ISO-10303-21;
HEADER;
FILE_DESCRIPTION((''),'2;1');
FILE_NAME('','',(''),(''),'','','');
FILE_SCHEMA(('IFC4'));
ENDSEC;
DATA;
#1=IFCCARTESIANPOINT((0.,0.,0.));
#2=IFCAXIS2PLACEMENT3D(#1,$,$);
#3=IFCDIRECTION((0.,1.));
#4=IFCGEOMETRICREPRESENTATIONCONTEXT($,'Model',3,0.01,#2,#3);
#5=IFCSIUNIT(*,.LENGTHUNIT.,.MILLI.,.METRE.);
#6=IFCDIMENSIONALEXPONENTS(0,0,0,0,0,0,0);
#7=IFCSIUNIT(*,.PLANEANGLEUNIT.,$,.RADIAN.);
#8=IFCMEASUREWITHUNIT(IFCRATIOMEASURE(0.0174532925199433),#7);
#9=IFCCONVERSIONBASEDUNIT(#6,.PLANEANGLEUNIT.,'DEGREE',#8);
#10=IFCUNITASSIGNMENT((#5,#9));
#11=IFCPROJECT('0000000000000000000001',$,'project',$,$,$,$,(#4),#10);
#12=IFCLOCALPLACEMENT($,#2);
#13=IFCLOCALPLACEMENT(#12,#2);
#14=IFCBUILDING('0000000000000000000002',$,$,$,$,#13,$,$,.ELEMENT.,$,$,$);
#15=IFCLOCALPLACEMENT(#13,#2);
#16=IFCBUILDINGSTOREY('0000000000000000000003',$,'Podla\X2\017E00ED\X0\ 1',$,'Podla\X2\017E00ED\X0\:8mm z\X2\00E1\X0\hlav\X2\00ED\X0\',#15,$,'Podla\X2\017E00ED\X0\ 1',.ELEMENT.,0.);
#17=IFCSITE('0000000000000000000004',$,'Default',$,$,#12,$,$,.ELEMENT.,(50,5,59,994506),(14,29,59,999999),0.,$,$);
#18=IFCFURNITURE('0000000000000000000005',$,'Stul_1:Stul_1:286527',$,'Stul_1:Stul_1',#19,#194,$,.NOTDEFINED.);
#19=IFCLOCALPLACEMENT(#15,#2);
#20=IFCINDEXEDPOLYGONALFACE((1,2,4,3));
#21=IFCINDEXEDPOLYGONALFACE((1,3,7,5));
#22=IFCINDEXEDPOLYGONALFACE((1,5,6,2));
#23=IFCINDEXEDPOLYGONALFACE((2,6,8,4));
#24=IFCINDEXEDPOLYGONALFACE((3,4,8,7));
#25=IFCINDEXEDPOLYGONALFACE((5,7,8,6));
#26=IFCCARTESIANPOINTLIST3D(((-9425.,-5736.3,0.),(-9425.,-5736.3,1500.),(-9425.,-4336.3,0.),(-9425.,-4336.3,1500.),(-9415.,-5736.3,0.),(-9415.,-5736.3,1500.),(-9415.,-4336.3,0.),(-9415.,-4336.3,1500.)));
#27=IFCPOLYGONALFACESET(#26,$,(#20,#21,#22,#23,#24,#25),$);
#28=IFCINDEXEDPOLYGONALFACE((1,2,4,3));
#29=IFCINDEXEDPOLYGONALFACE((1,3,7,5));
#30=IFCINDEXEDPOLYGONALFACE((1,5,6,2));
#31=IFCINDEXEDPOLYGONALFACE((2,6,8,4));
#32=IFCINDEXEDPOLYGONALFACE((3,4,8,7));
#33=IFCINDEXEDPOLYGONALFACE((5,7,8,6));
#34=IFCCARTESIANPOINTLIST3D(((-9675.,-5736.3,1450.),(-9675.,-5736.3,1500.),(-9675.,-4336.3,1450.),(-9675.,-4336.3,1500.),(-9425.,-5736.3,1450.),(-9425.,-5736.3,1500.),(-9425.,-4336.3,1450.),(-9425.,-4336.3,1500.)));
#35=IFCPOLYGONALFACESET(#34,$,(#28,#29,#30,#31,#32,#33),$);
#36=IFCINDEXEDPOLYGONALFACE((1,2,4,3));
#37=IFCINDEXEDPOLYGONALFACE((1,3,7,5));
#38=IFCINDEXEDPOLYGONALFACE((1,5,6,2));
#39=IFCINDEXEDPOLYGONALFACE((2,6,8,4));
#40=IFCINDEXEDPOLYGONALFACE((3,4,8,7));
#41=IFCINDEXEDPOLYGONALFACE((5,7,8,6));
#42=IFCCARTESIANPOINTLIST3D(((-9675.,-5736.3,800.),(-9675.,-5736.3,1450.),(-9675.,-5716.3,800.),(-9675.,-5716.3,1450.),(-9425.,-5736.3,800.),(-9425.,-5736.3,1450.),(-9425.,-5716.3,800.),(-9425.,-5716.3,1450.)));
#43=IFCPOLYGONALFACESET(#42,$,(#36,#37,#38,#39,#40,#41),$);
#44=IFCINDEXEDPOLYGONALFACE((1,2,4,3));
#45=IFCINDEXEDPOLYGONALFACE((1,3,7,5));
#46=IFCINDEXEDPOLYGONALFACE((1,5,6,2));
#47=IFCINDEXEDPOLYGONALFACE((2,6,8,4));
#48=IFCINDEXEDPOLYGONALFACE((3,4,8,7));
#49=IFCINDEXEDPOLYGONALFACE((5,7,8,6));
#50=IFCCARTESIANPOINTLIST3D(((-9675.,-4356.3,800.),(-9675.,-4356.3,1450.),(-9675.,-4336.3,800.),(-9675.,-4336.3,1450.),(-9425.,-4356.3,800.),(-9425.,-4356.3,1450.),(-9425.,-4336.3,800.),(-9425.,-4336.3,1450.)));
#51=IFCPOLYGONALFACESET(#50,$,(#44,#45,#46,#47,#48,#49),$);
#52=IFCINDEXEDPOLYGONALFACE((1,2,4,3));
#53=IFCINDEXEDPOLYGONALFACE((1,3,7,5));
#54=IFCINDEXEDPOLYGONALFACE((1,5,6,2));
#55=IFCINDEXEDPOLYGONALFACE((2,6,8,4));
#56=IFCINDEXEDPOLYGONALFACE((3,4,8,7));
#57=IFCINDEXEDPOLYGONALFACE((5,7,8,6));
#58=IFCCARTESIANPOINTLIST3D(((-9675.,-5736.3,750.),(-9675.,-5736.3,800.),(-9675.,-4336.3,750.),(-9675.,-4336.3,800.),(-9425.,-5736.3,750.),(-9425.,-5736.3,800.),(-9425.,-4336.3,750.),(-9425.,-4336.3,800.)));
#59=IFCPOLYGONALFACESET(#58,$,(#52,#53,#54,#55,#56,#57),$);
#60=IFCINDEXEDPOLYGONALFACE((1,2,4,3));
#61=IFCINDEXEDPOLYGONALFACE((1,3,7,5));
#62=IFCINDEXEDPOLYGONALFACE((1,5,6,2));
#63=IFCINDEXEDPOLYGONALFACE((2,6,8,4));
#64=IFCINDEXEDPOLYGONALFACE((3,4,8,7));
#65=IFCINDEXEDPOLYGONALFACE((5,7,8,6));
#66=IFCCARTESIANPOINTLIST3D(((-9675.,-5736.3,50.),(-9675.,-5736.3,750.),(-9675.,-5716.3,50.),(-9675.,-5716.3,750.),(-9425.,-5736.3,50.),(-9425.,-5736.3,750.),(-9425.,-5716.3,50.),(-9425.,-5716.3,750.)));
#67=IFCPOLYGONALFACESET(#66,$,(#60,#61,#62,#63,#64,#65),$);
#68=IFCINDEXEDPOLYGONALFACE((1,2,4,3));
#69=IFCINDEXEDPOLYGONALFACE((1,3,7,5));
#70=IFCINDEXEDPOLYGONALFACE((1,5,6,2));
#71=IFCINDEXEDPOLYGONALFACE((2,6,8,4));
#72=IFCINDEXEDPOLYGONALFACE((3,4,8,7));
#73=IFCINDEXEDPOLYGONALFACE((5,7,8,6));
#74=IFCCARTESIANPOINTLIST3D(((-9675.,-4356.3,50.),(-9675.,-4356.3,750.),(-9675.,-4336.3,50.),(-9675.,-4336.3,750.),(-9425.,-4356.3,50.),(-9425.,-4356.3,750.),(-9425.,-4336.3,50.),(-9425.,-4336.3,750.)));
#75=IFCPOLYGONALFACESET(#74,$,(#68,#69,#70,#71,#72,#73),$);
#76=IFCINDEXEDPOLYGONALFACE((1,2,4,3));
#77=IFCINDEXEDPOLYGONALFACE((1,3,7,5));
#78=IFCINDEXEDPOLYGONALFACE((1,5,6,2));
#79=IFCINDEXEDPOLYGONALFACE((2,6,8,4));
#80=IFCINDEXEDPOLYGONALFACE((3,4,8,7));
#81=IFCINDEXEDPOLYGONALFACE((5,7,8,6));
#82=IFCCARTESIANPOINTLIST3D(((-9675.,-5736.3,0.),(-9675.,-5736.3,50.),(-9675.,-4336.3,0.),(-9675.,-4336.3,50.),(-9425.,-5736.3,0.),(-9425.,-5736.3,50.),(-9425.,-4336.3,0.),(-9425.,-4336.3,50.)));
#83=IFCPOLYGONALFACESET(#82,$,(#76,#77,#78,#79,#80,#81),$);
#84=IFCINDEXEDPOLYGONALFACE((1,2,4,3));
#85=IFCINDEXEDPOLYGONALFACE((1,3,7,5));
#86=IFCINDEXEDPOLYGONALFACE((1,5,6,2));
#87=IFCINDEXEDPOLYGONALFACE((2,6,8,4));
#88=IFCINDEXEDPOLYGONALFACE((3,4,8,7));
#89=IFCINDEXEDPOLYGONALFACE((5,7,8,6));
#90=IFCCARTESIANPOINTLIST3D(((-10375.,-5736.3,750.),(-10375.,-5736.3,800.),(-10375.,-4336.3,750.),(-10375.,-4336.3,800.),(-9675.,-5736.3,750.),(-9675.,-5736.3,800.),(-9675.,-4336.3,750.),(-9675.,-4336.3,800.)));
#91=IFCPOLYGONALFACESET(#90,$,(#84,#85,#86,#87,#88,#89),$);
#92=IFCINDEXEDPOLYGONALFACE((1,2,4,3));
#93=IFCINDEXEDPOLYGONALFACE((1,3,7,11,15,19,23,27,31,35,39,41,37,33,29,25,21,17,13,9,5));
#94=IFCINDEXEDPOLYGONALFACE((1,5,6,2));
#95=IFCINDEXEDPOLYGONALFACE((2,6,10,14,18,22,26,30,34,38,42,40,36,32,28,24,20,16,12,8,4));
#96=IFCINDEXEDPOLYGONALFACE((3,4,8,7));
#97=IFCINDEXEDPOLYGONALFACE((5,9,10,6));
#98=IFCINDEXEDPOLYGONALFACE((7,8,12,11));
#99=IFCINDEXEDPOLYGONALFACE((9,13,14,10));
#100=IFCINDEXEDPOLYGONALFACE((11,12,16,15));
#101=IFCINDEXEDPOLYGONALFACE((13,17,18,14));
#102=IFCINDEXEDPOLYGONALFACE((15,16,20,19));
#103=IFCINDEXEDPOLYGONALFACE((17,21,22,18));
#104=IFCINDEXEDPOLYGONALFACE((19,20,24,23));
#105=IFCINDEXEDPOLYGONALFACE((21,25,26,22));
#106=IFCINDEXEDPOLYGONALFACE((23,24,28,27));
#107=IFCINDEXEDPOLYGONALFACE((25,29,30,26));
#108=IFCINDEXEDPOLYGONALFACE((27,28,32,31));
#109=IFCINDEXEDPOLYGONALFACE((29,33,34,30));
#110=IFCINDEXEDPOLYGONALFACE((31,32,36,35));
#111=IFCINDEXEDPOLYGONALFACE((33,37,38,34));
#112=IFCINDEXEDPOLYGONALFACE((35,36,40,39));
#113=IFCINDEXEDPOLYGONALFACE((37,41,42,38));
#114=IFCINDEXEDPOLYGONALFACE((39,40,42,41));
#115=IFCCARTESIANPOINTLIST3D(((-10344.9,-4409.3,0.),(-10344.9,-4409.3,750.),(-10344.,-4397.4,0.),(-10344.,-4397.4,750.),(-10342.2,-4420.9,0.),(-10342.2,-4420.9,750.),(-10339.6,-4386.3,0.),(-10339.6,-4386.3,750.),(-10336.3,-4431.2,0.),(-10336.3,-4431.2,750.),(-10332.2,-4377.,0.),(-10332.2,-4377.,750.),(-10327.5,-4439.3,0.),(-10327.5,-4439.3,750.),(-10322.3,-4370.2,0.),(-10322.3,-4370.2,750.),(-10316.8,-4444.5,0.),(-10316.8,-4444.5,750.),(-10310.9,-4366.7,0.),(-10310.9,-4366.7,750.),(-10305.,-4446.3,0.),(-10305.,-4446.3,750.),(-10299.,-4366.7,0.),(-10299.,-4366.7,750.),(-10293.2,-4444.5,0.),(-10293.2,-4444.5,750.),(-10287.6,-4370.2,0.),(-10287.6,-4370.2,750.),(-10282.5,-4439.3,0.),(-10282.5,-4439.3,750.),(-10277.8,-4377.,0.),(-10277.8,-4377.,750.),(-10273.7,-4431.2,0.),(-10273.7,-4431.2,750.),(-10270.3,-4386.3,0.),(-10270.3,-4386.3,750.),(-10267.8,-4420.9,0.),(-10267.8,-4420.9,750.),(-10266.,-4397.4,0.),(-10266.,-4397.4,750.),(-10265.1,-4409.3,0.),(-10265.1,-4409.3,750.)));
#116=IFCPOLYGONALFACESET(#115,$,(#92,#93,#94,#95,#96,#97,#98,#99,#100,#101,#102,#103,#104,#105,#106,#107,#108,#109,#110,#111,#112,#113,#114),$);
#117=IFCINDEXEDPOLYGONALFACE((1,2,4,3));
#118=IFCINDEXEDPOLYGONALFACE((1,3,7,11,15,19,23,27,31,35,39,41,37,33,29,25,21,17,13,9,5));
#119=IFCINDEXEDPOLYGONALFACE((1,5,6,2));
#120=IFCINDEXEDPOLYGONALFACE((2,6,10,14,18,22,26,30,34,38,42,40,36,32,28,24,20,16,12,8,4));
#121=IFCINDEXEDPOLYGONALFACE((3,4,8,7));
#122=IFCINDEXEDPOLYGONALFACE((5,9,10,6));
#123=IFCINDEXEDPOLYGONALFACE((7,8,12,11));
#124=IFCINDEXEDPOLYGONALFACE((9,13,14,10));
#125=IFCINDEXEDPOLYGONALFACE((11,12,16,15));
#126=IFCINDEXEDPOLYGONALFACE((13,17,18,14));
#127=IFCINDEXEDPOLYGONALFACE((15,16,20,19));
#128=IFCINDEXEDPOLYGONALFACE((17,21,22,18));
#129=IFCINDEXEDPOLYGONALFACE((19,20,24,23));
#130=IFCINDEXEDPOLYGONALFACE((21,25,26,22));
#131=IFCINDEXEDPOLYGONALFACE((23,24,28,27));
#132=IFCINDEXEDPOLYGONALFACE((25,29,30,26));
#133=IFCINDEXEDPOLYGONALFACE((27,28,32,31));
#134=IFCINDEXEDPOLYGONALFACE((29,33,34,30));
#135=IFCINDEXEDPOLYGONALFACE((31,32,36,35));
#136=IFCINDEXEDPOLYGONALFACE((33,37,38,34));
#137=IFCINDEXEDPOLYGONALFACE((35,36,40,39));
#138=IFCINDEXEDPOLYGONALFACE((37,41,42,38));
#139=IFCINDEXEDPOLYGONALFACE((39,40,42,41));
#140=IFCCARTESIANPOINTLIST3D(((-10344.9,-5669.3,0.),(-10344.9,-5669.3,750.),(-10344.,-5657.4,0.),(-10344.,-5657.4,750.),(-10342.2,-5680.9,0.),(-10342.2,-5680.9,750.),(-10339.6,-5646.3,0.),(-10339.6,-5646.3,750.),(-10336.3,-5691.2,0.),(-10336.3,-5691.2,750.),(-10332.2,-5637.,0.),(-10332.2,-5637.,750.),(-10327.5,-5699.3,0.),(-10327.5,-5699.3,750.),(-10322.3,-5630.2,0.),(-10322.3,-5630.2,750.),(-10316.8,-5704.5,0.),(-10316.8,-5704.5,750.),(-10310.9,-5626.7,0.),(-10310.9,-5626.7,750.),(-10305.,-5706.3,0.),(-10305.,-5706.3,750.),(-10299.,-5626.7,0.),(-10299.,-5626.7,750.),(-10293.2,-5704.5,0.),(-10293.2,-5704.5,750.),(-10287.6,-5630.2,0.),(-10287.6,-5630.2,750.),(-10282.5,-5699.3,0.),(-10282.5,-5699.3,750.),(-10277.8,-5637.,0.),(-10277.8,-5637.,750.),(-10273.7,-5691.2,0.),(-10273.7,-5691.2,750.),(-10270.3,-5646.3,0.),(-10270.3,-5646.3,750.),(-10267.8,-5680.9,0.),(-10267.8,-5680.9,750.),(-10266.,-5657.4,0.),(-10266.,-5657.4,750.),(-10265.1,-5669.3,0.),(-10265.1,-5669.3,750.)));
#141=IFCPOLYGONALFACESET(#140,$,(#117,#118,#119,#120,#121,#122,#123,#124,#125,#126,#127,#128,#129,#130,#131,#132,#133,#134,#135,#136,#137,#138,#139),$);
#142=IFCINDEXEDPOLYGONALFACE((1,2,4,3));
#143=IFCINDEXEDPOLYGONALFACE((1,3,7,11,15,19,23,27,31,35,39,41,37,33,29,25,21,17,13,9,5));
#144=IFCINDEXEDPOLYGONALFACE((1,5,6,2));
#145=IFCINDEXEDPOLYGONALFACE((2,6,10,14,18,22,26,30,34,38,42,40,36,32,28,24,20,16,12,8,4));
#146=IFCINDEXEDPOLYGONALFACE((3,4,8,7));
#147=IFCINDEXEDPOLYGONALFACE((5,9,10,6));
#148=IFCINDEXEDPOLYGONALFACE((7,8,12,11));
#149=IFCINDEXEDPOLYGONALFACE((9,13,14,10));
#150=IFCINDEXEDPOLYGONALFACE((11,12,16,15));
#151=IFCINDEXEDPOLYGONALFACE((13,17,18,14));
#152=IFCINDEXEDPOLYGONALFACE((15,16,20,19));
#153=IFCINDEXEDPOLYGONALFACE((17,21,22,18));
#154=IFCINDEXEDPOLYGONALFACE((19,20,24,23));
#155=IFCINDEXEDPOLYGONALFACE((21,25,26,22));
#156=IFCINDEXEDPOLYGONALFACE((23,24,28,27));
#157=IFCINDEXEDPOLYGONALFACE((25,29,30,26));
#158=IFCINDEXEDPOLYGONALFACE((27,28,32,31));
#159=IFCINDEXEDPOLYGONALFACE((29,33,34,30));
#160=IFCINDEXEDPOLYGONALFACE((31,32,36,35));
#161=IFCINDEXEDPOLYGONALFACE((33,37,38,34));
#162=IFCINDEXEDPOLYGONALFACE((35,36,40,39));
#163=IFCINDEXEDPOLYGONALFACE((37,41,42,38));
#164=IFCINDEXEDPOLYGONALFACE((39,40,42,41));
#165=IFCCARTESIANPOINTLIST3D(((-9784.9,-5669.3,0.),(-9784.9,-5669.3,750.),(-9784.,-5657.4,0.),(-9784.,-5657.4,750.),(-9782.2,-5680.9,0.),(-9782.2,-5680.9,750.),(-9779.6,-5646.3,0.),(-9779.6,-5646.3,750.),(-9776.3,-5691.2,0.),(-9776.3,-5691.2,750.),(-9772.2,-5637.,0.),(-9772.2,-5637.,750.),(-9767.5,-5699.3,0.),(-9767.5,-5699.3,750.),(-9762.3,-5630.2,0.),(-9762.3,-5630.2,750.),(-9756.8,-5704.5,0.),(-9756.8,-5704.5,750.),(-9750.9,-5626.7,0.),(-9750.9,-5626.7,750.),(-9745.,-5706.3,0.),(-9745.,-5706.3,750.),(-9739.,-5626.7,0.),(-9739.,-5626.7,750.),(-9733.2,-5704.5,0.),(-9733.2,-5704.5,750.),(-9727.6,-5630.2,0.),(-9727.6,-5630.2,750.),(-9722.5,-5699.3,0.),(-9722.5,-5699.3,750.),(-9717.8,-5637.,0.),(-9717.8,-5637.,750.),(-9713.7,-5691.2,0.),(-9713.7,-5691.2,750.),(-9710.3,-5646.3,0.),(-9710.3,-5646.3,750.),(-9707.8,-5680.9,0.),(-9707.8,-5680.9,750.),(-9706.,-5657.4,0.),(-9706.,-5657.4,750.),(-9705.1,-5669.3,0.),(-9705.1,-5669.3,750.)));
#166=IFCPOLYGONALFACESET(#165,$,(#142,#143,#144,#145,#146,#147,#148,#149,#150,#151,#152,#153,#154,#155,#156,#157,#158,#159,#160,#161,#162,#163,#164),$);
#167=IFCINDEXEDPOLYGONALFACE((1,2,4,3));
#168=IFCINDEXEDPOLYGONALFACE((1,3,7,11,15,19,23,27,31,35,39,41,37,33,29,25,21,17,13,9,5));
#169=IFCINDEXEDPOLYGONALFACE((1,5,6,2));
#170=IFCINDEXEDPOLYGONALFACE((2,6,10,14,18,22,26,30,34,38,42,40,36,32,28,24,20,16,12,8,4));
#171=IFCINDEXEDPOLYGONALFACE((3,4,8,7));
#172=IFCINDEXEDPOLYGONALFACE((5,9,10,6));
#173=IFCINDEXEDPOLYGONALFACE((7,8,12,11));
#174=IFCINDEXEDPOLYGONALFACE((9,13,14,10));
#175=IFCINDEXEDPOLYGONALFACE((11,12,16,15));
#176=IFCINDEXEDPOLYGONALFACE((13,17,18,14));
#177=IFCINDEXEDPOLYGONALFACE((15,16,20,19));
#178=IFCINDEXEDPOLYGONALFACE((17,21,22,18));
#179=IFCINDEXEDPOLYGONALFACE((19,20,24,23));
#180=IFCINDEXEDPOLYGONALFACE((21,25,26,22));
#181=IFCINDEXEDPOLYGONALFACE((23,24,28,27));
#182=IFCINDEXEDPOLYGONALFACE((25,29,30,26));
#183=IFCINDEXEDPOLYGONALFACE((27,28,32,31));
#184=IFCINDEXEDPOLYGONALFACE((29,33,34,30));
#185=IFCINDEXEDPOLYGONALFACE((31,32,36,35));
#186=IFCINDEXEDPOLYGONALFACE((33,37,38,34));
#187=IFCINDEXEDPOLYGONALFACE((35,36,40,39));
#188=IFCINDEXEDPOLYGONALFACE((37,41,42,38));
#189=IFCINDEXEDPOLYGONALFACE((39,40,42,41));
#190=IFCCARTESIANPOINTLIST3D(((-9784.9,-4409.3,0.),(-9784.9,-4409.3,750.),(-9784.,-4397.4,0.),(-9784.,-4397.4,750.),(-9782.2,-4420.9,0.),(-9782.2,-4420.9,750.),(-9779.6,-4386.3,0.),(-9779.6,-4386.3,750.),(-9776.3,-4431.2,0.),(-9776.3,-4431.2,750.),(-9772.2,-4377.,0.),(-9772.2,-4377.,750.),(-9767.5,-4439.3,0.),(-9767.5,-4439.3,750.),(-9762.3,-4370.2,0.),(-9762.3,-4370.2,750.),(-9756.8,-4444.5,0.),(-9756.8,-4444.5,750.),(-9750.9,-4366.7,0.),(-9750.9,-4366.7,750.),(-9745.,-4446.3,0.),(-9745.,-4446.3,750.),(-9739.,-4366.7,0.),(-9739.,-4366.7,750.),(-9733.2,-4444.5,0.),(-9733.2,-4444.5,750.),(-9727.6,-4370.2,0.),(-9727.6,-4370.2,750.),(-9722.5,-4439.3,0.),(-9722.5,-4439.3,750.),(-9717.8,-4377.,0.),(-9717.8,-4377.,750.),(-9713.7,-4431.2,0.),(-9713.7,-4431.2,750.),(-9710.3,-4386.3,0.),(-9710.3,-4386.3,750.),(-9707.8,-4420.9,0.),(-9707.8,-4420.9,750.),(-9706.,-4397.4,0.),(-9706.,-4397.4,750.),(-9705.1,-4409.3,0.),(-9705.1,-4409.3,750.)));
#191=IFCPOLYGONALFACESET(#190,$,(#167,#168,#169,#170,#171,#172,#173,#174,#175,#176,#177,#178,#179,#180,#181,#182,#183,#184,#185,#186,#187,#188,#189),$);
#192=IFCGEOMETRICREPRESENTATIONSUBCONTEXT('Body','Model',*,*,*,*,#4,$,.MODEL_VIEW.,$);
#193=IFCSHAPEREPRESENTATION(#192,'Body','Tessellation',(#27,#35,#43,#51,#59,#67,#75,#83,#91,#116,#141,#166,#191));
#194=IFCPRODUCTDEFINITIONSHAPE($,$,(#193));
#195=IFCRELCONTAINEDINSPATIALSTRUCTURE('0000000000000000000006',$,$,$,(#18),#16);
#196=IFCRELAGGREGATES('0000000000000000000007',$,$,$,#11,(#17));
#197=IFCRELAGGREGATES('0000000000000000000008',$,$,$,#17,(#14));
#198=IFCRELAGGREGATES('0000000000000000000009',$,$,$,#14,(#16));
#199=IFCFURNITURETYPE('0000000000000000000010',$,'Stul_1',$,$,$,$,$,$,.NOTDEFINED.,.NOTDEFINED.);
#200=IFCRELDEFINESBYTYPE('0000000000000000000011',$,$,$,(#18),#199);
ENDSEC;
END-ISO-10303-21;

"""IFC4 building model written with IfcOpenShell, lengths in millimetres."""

from ifc_helpers import new_model, entity, si_unit, converted_unit, direction, frame, frame_2d, origin, origin_2d_with_axis, place, context, subcontext, project, spatial, rectangle, circle, extrude, source, transform, mapped, type_object, type_shapes, element, save


model = new_model("IFC4")

# Units and contexts
model_context = context("Model", 3, precision=0.01, world=origin(), true_north=direction((0.0, 1.0)))
body_context = subcontext(model_context, "Body", "Model", "MODEL_VIEW")
ifc_project = project(units=[si_unit("LENGTHUNIT", "METRE", prefix="MILLI"), converted_unit("PLANEANGLEUNIT", "DEGREE", entity("IfcRatioMeasure", 0.0174532925199433), si_unit("PLANEANGLEUNIT", "RADIAN"), dimensions=[0, 0, 0, 0, 0, 0, 0])], contexts=[model_context])

# Site, building, storey
site_placement = place(None, origin())
site = spatial("IfcSite", under=ifc_project, at=site_placement, Name="Default", CompositionType="ELEMENT", RefLatitude=(50, 5, 59, 994506), RefLongitude=(14, 29, 59, 999999), RefElevation=0.0)
building_placement = place(site_placement, origin())
building = spatial("IfcBuilding", under=site, at=building_placement, CompositionType="ELEMENT")
storey_placement = place(building_placement, origin())
storey = spatial("IfcBuildingStorey", under=building, at=storey_placement, Name="Podlaží 1", ObjectType="Podlaží:8mm záhlaví", LongName="Podlaží 1", CompositionType="ELEMENT", Elevation=0.0)

# Furniture
furniture_type = type_object("IfcFurnitureType", Name="Stul_1", AssemblyPlace="NOTDEFINED", PredefinedType="NOTDEFINED")
shared_shape_1 = source(origin(), body_context, "Body", "SweptSolid", [
    extrude(rectangle(XDim=1400.0, YDim=10.0, at=origin_2d_with_axis()), frame((0.0, 605.0, 0.0), z_axis=(0.0, 0.0, 1.0), x_axis=(-1.0, 0.0, 0.0)), (0.0, 0.0, 1.0), 1500.0),
    extrude(rectangle(XDim=1400.0, YDim=250.0, at=frame_2d((0.0, 0.0), x_axis=(1.0, 0.0))), frame((0.0, 475.0, 1450.0), z_axis=(0.0, 0.0, 1.0), x_axis=(-1.0, 0.0, 0.0)), (0.0, 0.0, 1.0), 50.0),
    extrude(rectangle(XDim=20.0, YDim=250.0, at=origin_2d_with_axis()), frame((690.0, 475.0, 800.0), z_axis=(0.0, 0.0, 1.0), x_axis=(-1.0, 0.0, 0.0)), (0.0, 0.0, 1.0), 650.0),
    extrude(rectangle(XDim=20.0, YDim=250.0, at=frame_2d((0.0, 0.0), x_axis=(1.0, 0.0))), frame((-690.0, 475.0, 800.0), z_axis=(0.0, 0.0, 1.0), x_axis=(-1.0, 0.0, 0.0)), (0.0, 0.0, 1.0), 650.0),
    extrude(rectangle(XDim=1400.0, YDim=250.0, at=origin_2d_with_axis()), frame((0.0, 475.0, 750.0), z_axis=(0.0, 0.0, 1.0), x_axis=(-1.0, 0.0, 0.0)), (0.0, 0.0, 1.0), 50.0),
    extrude(rectangle(XDim=20.0, YDim=250.0, at=origin_2d_with_axis()), frame((690.0, 475.0, 50.0), z_axis=(0.0, 0.0, 1.0), x_axis=(-1.0, 0.0, 0.0)), (0.0, 0.0, 1.0), 700.0),
    extrude(rectangle(XDim=20.0, YDim=250.0, at=frame_2d((0.0, 0.0), x_axis=(1.0, 0.0))), frame((-690.0, 475.0, 50.0), z_axis=(0.0, 0.0, 1.0), x_axis=(-1.0, 0.0, 0.0)), (0.0, 0.0, 1.0), 700.0),
    extrude(rectangle(XDim=1400.0, YDim=250.0, at=origin_2d_with_axis()), frame((0.0, 475.0, 0.0), z_axis=(0.0, 0.0, 1.0), x_axis=(-1.0, 0.0, 0.0)), (0.0, 0.0, 1.0), 50.0),
    extrude(rectangle(XDim=1400.0, YDim=700.0, at=origin_2d_with_axis()), frame((0.0, 0.0, 750.0), z_axis=(0.0, 0.0, 1.0), x_axis=(-1.0, 0.0, 0.0)), (0.0, 0.0, 1.0), 50.0),
    extrude(circle(Radius=40.0, at=frame_2d((0.0, 0.0), x_axis=(1.0, 0.0))), frame((-630.0, -280.0, 0.0)), (0.0, 0.0, 1.0), 750.0),
    extrude(circle(Radius=40.0, at=frame_2d((0.0, 0.0), x_axis=(1.0, 0.0))), frame((630.0, -280.0, 0.0)), (0.0, 0.0, 1.0), 750.0),
    extrude(circle(Radius=40.0, at=frame_2d((0.0, 0.0), x_axis=(1.0, 0.0))), frame((630.0, 280.0, 0.0)), (0.0, 0.0, 1.0), 750.0),
    extrude(circle(Radius=40.0, at=frame_2d((0.0, 0.0), x_axis=(1.0, 0.0))), frame((-630.0, 280.0, 0.0)), (0.0, 0.0, 1.0), 750.0),
])
type_shapes(furniture_type, [shared_shape_1])
for number, where, z_axis, x_axis, name in (
    (1, (-10025.0, -5036.3, 0.0), (0.0, 0.0, 1.0), (0.0, -1.0, 0.0), "Stul_1:Stul_1:286527"),
):
    element("IfcFurniture", number, at=place(storey_placement, frame(where, z_axis=z_axis, x_axis=x_axis)), inside=storey, type_object=furniture_type, Name=name, ObjectType="Stul_1:Stul_1", PredefinedType="NOTDEFINED", context=body_context, shape_type="MappedRepresentation", body=[
        mapped(shared_shape_1, transform((0.0, 0.0, 0.0), scale=1.0)),
    ])

save(model, "model.ifc")
